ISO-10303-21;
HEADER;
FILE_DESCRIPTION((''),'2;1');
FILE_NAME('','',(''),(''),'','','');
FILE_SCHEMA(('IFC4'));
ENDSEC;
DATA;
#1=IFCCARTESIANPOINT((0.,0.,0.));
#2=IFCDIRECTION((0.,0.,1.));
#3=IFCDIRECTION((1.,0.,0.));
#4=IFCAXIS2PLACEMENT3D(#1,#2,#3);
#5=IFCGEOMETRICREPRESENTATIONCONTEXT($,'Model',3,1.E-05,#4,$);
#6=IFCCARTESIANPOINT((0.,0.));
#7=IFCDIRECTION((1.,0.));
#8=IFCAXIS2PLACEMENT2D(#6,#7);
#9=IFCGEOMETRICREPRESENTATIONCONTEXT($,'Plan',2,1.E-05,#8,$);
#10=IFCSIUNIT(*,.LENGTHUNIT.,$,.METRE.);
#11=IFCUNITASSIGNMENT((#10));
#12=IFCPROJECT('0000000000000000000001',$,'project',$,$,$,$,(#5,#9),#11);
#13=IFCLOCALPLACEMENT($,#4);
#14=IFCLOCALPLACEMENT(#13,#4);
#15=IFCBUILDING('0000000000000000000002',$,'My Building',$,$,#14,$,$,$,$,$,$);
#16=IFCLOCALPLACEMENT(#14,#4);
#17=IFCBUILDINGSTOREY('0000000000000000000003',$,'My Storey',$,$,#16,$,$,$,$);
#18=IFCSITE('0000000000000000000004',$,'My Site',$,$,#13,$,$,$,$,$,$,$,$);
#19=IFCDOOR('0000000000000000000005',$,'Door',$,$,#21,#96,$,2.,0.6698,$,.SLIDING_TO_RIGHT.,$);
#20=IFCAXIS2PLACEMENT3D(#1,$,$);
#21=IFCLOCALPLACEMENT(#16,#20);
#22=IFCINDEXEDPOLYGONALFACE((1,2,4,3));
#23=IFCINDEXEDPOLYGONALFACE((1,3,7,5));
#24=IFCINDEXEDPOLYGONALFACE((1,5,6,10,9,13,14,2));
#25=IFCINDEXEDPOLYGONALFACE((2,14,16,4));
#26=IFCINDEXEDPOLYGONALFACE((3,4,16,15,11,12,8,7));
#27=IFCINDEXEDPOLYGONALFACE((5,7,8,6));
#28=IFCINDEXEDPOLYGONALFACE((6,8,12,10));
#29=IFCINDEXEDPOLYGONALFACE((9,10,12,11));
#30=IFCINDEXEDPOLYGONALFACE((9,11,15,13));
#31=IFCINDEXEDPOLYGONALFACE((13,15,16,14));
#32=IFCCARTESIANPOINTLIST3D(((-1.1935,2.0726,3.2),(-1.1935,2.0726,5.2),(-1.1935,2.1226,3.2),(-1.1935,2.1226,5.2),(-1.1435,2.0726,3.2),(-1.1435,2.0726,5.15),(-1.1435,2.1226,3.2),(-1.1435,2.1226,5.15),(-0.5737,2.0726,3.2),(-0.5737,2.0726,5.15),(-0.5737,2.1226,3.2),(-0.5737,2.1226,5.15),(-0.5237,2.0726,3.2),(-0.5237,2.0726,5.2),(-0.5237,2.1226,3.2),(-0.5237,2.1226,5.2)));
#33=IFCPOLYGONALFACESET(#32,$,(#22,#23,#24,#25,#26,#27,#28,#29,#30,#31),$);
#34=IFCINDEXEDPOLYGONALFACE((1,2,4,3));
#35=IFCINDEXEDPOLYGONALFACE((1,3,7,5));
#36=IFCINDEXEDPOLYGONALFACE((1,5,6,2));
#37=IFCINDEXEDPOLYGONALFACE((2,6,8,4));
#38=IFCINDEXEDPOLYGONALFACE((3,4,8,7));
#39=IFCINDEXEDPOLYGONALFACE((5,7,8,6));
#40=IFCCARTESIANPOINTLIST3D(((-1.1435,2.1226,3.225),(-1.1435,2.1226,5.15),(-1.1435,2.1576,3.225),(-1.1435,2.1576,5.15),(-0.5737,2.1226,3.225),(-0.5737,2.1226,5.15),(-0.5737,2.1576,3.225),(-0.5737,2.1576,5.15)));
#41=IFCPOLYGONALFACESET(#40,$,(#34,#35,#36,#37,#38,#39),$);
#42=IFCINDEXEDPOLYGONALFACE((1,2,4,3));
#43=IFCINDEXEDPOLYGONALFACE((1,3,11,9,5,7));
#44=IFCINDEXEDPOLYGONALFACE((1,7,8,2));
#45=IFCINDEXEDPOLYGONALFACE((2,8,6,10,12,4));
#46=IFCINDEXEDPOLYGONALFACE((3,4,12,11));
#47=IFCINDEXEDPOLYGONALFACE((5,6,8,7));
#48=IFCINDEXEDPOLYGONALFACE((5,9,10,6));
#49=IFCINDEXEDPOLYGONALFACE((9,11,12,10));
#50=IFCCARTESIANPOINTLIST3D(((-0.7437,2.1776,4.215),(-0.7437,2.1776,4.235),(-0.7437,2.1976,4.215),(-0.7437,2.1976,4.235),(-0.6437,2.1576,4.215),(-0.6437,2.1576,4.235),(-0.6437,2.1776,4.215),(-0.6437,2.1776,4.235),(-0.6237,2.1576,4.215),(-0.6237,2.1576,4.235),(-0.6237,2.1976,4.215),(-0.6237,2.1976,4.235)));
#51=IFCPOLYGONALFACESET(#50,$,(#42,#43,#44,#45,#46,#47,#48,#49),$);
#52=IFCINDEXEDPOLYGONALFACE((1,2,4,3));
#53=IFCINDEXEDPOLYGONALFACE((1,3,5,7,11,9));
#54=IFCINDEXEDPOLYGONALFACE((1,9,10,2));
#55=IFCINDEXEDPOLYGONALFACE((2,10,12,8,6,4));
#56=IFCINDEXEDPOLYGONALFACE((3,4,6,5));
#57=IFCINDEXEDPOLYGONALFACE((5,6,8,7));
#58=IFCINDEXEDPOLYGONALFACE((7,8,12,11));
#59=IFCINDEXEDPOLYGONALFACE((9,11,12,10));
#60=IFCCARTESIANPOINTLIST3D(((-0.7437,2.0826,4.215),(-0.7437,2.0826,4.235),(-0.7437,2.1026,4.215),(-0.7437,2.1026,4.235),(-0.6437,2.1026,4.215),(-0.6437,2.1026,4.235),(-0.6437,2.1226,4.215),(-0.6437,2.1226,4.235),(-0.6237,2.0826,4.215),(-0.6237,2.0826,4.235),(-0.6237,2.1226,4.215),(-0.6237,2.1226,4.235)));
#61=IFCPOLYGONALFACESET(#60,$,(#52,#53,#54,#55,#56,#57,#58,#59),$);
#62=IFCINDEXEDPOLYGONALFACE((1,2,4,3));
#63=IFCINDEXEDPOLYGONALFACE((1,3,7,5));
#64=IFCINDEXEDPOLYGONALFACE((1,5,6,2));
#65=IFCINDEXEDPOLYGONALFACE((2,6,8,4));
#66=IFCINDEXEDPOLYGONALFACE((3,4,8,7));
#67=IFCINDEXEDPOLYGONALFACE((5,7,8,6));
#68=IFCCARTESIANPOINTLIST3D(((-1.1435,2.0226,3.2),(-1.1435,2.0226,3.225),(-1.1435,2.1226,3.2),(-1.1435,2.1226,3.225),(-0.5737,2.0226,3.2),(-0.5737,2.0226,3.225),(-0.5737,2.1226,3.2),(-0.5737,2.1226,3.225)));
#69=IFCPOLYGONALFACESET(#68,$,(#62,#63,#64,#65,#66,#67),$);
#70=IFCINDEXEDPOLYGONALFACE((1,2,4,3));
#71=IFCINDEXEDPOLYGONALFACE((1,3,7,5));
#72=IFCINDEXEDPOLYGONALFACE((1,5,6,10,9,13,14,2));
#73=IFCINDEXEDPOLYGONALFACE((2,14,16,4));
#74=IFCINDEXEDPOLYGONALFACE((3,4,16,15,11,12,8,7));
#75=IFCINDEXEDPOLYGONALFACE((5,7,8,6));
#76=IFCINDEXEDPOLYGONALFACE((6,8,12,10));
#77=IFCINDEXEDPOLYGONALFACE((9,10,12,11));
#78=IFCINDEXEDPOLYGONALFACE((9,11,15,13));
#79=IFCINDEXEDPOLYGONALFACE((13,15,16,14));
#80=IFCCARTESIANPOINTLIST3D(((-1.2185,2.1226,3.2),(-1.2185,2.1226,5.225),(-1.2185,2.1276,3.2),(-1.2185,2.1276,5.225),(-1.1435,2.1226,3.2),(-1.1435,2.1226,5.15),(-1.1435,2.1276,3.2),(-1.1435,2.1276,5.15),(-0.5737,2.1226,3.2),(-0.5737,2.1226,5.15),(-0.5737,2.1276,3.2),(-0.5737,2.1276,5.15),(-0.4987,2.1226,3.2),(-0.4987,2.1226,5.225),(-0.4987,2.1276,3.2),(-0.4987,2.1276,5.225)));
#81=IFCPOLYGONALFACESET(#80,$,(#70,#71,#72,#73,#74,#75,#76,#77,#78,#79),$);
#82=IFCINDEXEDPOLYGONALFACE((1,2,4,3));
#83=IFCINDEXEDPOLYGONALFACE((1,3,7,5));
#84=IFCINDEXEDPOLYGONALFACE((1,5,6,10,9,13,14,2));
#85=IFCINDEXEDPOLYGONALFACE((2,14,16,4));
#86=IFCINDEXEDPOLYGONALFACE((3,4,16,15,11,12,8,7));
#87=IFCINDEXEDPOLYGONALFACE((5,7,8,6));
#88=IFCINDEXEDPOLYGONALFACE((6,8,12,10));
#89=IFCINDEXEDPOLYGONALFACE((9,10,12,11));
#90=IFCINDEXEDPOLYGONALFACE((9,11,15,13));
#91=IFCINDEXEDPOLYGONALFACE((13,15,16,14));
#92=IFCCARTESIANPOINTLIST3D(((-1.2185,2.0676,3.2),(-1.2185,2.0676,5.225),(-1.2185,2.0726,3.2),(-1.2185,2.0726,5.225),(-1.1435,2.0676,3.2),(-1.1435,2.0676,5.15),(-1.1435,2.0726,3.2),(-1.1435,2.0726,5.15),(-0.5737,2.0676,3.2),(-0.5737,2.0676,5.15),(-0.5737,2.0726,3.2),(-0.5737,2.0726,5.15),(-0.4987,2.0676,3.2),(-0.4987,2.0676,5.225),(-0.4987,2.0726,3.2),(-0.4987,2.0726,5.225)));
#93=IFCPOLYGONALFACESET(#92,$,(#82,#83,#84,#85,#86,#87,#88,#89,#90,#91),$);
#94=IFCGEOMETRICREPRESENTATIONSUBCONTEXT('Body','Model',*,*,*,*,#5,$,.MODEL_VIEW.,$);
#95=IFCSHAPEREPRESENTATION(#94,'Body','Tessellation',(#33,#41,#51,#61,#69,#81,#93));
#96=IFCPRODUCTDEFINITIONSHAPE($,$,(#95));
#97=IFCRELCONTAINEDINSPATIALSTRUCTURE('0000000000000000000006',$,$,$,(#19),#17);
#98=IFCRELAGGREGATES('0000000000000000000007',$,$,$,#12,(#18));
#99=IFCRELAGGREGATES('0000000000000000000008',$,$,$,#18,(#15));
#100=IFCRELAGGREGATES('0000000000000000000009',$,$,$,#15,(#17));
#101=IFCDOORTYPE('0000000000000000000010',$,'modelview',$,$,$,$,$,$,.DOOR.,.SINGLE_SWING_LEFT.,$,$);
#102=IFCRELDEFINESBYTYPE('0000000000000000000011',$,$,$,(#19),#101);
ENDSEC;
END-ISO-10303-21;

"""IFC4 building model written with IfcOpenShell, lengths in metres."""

from ifc_helpers import new_model, entity, si_unit, frame, origin_with_axes, origin_2d_with_axis, place, context, subcontext, project, spatial, line, indexed_curve, outline, extrude, shape, source, transform, mapped, type_object, type_shapes, element, save


model = new_model("IFC4")

# Units and contexts
model_context = context("Model", 3, precision=1e-05, world=origin_with_axes())
plan_context = context("Plan", 2, precision=1e-05, world=origin_2d_with_axis())
body_context_1 = subcontext(model_context, "Body", "Model", "MODEL_VIEW")
body_context_2 = subcontext(plan_context, "Body", "Plan", "PLAN_VIEW")
ifc_project = project(units=[si_unit("LENGTHUNIT", "METRE")], contexts=[model_context, plan_context])

# Site, building, storey
site_placement = place(None, origin_with_axes())
site = spatial("IfcSite", under=ifc_project, at=site_placement, Name="My Site")
building_placement = place(site_placement, origin_with_axes())
building = spatial("IfcBuilding", under=site, at=building_placement, Name="My Building")
storey_placement = place(building_placement, origin_with_axes())
storey = spatial("IfcBuildingStorey", under=building, at=storey_placement, Name="My Storey")

# Shared definitions
door_type_1 = type_object("IfcDoorType", Name="modelview", OperationType="SINGLE_SWING_LEFT", PredefinedType="DOOR")
shared_shape_1 = source(origin_with_axes(), body_context_1, "Body", "SweptSolid", [
    extrude(outline(indexed_curve([(0.0, 0.0), (0.0, 2.0), (0.6698, 2.0), (0.6698, 0.0), (0.6198, 0.0), (0.6198, 1.95), (0.05, 1.95), (0.05, 0.0)], segments=[line(1, 2, 3, 4, 5, 6, 7, 8, 1)])), frame((0.0, 0.0, 0.0), z_axis=(0.0, -1.0, 0.0), x_axis=(1.0, 0.0, 0.0)), (0.0, 0.0, -1.0), 0.05),
    extrude(outline(indexed_curve([(0.0, 0.0), (0.5698, 0.0), (0.5698, 0.035), (0.0, 0.035)], segments=[line(1, 2, 3, 4, 1)])), frame((0.05, -0.035, 0.025), z_axis=(0.0, 0.0, 1.0), x_axis=(1.0, 0.0, 0.0)), (0.0, 0.0, 1.0), 1.925),
    extrude(outline(indexed_curve([(0.0, 0.0), (0.0, -0.04), (0.12, -0.04), (0.12, -0.02), (0.02, -0.02), (0.02, 0.0)], segments=[line(1, 2, 3, 4, 5, 6, 1)])), frame((0.1, -0.035, 1.015), z_axis=(0.0, 0.0, 1.0), x_axis=(1.0, 0.0, 0.0)), (0.0, 0.0, 1.0), 0.02),
    extrude(outline(indexed_curve([(0.0, 0.0), (0.0, 0.04), (0.12, 0.04), (0.12, 0.02), (0.02, 0.02), (0.02, 0.0)], segments=[line(1, 2, 3, 4, 5, 6, 1)])), frame((0.1, 0.0, 1.015), z_axis=(0.0, 0.0, 1.0), x_axis=(1.0, 0.0, 0.0)), (0.0, 0.0, 1.0), 0.02),
    extrude(outline(indexed_curve([(0.0, 0.0), (0.5698, 0.0), (0.5698, 0.1), (0.0, 0.1)], segments=[line(1, 2, 3, 4, 1)])), frame((0.05, 0.0, 0.0), z_axis=(0.0, 0.0, 1.0), x_axis=(1.0, 0.0, 0.0)), (0.0, 0.0, 1.0), 0.025),
    extrude(outline(indexed_curve([(0.0, 0.0), (0.0, 2.025), (0.7198, 2.025), (0.7198, 0.0), (0.6448, 0.0), (0.6448, 1.95), (0.075, 1.95), (0.075, 0.0)], segments=[line(1, 2, 3, 4, 5, 6, 7, 8, 1)])), frame((-0.025, -0.005, 0.0), z_axis=(0.0, -1.0, 0.0), x_axis=(1.0, 0.0, 0.0)), (0.0, 0.0, -1.0), 0.005),
    extrude(outline(indexed_curve([(0.0, 0.0), (0.0, 2.025), (0.7198, 2.025), (0.7198, 0.0), (0.6448, 0.0), (0.6448, 1.95), (0.075, 1.95), (0.075, 0.0)], segments=[line(1, 2, 3, 4, 5, 6, 7, 8, 1)])), frame((-0.025, 0.05, 0.0), z_axis=(0.0, -1.0, 0.0), x_axis=(1.0, 0.0, 0.0)), (0.0, 0.0, -1.0), 0.005),
])
shared_shape_2 = source(origin_with_axes(), body_context_2, "Body", "Curve2D", [
    entity("IfcIndexedPolyCurve", entity("IfcCartesianPointList2D", [[0.0, 0.0], [0.05, 0.0], [0.05, 0.05], [0.0, 0.05]]), [entity("IfcLineIndex", [1, 2, 3, 4, 1])]),
    entity("IfcIndexedPolyCurve", entity("IfcCartesianPointList2D", [[0.6698, 0.0], [0.6198, 0.0], [0.6198, 0.05], [0.6698, 0.05]]), [entity("IfcLineIndex", [1, 2, 3, 4, 1])]),
    entity("IfcIndexedPolyCurve", entity("IfcCartesianPointList2D", [[0.9047, -0.035], [0.3349, -0.035], [0.3349, 0.0], [0.9047, 0.0]]), [entity("IfcLineIndex", [1, 2, 3, 4, 1])]),
])
type_shapes(door_type_1, [shared_shape_1, shared_shape_2])

# Door
door_1_placement = place(storey_placement, frame((-0.5237, 2.1226, 3.2), z_axis=(0.0, 0.0, 1.0), x_axis=(-1.0, 0.0, 0.0)))
element("IfcDoor", 1, at=door_1_placement, inside=storey, type_object=door_type_1, Name="Door", OperationType="SLIDING_TO_RIGHT", OverallHeight=2.0, OverallWidth=0.6698, shapes=[
    shape(body_context_1, "Body", "MappedRepresentation", [mapped(shared_shape_1, transform((0.0, 0.0, 0.0), x_axis=(1.0, 0.0, 0.0), y_axis=(0.0, 1.0, 0.0), z_axis=(0.0, 0.0, 1.0), scale=1.0))]),
    shape(body_context_2, "Body", "MappedRepresentation", [mapped(shared_shape_2, transform((0.0, 0.0, 0.0), x_axis=(1.0, 0.0, 0.0), y_axis=(0.0, 1.0, 0.0), z_axis=(0.0, 0.0, 1.0), scale=1.0))]),
])

save(model, "model.ifc")
